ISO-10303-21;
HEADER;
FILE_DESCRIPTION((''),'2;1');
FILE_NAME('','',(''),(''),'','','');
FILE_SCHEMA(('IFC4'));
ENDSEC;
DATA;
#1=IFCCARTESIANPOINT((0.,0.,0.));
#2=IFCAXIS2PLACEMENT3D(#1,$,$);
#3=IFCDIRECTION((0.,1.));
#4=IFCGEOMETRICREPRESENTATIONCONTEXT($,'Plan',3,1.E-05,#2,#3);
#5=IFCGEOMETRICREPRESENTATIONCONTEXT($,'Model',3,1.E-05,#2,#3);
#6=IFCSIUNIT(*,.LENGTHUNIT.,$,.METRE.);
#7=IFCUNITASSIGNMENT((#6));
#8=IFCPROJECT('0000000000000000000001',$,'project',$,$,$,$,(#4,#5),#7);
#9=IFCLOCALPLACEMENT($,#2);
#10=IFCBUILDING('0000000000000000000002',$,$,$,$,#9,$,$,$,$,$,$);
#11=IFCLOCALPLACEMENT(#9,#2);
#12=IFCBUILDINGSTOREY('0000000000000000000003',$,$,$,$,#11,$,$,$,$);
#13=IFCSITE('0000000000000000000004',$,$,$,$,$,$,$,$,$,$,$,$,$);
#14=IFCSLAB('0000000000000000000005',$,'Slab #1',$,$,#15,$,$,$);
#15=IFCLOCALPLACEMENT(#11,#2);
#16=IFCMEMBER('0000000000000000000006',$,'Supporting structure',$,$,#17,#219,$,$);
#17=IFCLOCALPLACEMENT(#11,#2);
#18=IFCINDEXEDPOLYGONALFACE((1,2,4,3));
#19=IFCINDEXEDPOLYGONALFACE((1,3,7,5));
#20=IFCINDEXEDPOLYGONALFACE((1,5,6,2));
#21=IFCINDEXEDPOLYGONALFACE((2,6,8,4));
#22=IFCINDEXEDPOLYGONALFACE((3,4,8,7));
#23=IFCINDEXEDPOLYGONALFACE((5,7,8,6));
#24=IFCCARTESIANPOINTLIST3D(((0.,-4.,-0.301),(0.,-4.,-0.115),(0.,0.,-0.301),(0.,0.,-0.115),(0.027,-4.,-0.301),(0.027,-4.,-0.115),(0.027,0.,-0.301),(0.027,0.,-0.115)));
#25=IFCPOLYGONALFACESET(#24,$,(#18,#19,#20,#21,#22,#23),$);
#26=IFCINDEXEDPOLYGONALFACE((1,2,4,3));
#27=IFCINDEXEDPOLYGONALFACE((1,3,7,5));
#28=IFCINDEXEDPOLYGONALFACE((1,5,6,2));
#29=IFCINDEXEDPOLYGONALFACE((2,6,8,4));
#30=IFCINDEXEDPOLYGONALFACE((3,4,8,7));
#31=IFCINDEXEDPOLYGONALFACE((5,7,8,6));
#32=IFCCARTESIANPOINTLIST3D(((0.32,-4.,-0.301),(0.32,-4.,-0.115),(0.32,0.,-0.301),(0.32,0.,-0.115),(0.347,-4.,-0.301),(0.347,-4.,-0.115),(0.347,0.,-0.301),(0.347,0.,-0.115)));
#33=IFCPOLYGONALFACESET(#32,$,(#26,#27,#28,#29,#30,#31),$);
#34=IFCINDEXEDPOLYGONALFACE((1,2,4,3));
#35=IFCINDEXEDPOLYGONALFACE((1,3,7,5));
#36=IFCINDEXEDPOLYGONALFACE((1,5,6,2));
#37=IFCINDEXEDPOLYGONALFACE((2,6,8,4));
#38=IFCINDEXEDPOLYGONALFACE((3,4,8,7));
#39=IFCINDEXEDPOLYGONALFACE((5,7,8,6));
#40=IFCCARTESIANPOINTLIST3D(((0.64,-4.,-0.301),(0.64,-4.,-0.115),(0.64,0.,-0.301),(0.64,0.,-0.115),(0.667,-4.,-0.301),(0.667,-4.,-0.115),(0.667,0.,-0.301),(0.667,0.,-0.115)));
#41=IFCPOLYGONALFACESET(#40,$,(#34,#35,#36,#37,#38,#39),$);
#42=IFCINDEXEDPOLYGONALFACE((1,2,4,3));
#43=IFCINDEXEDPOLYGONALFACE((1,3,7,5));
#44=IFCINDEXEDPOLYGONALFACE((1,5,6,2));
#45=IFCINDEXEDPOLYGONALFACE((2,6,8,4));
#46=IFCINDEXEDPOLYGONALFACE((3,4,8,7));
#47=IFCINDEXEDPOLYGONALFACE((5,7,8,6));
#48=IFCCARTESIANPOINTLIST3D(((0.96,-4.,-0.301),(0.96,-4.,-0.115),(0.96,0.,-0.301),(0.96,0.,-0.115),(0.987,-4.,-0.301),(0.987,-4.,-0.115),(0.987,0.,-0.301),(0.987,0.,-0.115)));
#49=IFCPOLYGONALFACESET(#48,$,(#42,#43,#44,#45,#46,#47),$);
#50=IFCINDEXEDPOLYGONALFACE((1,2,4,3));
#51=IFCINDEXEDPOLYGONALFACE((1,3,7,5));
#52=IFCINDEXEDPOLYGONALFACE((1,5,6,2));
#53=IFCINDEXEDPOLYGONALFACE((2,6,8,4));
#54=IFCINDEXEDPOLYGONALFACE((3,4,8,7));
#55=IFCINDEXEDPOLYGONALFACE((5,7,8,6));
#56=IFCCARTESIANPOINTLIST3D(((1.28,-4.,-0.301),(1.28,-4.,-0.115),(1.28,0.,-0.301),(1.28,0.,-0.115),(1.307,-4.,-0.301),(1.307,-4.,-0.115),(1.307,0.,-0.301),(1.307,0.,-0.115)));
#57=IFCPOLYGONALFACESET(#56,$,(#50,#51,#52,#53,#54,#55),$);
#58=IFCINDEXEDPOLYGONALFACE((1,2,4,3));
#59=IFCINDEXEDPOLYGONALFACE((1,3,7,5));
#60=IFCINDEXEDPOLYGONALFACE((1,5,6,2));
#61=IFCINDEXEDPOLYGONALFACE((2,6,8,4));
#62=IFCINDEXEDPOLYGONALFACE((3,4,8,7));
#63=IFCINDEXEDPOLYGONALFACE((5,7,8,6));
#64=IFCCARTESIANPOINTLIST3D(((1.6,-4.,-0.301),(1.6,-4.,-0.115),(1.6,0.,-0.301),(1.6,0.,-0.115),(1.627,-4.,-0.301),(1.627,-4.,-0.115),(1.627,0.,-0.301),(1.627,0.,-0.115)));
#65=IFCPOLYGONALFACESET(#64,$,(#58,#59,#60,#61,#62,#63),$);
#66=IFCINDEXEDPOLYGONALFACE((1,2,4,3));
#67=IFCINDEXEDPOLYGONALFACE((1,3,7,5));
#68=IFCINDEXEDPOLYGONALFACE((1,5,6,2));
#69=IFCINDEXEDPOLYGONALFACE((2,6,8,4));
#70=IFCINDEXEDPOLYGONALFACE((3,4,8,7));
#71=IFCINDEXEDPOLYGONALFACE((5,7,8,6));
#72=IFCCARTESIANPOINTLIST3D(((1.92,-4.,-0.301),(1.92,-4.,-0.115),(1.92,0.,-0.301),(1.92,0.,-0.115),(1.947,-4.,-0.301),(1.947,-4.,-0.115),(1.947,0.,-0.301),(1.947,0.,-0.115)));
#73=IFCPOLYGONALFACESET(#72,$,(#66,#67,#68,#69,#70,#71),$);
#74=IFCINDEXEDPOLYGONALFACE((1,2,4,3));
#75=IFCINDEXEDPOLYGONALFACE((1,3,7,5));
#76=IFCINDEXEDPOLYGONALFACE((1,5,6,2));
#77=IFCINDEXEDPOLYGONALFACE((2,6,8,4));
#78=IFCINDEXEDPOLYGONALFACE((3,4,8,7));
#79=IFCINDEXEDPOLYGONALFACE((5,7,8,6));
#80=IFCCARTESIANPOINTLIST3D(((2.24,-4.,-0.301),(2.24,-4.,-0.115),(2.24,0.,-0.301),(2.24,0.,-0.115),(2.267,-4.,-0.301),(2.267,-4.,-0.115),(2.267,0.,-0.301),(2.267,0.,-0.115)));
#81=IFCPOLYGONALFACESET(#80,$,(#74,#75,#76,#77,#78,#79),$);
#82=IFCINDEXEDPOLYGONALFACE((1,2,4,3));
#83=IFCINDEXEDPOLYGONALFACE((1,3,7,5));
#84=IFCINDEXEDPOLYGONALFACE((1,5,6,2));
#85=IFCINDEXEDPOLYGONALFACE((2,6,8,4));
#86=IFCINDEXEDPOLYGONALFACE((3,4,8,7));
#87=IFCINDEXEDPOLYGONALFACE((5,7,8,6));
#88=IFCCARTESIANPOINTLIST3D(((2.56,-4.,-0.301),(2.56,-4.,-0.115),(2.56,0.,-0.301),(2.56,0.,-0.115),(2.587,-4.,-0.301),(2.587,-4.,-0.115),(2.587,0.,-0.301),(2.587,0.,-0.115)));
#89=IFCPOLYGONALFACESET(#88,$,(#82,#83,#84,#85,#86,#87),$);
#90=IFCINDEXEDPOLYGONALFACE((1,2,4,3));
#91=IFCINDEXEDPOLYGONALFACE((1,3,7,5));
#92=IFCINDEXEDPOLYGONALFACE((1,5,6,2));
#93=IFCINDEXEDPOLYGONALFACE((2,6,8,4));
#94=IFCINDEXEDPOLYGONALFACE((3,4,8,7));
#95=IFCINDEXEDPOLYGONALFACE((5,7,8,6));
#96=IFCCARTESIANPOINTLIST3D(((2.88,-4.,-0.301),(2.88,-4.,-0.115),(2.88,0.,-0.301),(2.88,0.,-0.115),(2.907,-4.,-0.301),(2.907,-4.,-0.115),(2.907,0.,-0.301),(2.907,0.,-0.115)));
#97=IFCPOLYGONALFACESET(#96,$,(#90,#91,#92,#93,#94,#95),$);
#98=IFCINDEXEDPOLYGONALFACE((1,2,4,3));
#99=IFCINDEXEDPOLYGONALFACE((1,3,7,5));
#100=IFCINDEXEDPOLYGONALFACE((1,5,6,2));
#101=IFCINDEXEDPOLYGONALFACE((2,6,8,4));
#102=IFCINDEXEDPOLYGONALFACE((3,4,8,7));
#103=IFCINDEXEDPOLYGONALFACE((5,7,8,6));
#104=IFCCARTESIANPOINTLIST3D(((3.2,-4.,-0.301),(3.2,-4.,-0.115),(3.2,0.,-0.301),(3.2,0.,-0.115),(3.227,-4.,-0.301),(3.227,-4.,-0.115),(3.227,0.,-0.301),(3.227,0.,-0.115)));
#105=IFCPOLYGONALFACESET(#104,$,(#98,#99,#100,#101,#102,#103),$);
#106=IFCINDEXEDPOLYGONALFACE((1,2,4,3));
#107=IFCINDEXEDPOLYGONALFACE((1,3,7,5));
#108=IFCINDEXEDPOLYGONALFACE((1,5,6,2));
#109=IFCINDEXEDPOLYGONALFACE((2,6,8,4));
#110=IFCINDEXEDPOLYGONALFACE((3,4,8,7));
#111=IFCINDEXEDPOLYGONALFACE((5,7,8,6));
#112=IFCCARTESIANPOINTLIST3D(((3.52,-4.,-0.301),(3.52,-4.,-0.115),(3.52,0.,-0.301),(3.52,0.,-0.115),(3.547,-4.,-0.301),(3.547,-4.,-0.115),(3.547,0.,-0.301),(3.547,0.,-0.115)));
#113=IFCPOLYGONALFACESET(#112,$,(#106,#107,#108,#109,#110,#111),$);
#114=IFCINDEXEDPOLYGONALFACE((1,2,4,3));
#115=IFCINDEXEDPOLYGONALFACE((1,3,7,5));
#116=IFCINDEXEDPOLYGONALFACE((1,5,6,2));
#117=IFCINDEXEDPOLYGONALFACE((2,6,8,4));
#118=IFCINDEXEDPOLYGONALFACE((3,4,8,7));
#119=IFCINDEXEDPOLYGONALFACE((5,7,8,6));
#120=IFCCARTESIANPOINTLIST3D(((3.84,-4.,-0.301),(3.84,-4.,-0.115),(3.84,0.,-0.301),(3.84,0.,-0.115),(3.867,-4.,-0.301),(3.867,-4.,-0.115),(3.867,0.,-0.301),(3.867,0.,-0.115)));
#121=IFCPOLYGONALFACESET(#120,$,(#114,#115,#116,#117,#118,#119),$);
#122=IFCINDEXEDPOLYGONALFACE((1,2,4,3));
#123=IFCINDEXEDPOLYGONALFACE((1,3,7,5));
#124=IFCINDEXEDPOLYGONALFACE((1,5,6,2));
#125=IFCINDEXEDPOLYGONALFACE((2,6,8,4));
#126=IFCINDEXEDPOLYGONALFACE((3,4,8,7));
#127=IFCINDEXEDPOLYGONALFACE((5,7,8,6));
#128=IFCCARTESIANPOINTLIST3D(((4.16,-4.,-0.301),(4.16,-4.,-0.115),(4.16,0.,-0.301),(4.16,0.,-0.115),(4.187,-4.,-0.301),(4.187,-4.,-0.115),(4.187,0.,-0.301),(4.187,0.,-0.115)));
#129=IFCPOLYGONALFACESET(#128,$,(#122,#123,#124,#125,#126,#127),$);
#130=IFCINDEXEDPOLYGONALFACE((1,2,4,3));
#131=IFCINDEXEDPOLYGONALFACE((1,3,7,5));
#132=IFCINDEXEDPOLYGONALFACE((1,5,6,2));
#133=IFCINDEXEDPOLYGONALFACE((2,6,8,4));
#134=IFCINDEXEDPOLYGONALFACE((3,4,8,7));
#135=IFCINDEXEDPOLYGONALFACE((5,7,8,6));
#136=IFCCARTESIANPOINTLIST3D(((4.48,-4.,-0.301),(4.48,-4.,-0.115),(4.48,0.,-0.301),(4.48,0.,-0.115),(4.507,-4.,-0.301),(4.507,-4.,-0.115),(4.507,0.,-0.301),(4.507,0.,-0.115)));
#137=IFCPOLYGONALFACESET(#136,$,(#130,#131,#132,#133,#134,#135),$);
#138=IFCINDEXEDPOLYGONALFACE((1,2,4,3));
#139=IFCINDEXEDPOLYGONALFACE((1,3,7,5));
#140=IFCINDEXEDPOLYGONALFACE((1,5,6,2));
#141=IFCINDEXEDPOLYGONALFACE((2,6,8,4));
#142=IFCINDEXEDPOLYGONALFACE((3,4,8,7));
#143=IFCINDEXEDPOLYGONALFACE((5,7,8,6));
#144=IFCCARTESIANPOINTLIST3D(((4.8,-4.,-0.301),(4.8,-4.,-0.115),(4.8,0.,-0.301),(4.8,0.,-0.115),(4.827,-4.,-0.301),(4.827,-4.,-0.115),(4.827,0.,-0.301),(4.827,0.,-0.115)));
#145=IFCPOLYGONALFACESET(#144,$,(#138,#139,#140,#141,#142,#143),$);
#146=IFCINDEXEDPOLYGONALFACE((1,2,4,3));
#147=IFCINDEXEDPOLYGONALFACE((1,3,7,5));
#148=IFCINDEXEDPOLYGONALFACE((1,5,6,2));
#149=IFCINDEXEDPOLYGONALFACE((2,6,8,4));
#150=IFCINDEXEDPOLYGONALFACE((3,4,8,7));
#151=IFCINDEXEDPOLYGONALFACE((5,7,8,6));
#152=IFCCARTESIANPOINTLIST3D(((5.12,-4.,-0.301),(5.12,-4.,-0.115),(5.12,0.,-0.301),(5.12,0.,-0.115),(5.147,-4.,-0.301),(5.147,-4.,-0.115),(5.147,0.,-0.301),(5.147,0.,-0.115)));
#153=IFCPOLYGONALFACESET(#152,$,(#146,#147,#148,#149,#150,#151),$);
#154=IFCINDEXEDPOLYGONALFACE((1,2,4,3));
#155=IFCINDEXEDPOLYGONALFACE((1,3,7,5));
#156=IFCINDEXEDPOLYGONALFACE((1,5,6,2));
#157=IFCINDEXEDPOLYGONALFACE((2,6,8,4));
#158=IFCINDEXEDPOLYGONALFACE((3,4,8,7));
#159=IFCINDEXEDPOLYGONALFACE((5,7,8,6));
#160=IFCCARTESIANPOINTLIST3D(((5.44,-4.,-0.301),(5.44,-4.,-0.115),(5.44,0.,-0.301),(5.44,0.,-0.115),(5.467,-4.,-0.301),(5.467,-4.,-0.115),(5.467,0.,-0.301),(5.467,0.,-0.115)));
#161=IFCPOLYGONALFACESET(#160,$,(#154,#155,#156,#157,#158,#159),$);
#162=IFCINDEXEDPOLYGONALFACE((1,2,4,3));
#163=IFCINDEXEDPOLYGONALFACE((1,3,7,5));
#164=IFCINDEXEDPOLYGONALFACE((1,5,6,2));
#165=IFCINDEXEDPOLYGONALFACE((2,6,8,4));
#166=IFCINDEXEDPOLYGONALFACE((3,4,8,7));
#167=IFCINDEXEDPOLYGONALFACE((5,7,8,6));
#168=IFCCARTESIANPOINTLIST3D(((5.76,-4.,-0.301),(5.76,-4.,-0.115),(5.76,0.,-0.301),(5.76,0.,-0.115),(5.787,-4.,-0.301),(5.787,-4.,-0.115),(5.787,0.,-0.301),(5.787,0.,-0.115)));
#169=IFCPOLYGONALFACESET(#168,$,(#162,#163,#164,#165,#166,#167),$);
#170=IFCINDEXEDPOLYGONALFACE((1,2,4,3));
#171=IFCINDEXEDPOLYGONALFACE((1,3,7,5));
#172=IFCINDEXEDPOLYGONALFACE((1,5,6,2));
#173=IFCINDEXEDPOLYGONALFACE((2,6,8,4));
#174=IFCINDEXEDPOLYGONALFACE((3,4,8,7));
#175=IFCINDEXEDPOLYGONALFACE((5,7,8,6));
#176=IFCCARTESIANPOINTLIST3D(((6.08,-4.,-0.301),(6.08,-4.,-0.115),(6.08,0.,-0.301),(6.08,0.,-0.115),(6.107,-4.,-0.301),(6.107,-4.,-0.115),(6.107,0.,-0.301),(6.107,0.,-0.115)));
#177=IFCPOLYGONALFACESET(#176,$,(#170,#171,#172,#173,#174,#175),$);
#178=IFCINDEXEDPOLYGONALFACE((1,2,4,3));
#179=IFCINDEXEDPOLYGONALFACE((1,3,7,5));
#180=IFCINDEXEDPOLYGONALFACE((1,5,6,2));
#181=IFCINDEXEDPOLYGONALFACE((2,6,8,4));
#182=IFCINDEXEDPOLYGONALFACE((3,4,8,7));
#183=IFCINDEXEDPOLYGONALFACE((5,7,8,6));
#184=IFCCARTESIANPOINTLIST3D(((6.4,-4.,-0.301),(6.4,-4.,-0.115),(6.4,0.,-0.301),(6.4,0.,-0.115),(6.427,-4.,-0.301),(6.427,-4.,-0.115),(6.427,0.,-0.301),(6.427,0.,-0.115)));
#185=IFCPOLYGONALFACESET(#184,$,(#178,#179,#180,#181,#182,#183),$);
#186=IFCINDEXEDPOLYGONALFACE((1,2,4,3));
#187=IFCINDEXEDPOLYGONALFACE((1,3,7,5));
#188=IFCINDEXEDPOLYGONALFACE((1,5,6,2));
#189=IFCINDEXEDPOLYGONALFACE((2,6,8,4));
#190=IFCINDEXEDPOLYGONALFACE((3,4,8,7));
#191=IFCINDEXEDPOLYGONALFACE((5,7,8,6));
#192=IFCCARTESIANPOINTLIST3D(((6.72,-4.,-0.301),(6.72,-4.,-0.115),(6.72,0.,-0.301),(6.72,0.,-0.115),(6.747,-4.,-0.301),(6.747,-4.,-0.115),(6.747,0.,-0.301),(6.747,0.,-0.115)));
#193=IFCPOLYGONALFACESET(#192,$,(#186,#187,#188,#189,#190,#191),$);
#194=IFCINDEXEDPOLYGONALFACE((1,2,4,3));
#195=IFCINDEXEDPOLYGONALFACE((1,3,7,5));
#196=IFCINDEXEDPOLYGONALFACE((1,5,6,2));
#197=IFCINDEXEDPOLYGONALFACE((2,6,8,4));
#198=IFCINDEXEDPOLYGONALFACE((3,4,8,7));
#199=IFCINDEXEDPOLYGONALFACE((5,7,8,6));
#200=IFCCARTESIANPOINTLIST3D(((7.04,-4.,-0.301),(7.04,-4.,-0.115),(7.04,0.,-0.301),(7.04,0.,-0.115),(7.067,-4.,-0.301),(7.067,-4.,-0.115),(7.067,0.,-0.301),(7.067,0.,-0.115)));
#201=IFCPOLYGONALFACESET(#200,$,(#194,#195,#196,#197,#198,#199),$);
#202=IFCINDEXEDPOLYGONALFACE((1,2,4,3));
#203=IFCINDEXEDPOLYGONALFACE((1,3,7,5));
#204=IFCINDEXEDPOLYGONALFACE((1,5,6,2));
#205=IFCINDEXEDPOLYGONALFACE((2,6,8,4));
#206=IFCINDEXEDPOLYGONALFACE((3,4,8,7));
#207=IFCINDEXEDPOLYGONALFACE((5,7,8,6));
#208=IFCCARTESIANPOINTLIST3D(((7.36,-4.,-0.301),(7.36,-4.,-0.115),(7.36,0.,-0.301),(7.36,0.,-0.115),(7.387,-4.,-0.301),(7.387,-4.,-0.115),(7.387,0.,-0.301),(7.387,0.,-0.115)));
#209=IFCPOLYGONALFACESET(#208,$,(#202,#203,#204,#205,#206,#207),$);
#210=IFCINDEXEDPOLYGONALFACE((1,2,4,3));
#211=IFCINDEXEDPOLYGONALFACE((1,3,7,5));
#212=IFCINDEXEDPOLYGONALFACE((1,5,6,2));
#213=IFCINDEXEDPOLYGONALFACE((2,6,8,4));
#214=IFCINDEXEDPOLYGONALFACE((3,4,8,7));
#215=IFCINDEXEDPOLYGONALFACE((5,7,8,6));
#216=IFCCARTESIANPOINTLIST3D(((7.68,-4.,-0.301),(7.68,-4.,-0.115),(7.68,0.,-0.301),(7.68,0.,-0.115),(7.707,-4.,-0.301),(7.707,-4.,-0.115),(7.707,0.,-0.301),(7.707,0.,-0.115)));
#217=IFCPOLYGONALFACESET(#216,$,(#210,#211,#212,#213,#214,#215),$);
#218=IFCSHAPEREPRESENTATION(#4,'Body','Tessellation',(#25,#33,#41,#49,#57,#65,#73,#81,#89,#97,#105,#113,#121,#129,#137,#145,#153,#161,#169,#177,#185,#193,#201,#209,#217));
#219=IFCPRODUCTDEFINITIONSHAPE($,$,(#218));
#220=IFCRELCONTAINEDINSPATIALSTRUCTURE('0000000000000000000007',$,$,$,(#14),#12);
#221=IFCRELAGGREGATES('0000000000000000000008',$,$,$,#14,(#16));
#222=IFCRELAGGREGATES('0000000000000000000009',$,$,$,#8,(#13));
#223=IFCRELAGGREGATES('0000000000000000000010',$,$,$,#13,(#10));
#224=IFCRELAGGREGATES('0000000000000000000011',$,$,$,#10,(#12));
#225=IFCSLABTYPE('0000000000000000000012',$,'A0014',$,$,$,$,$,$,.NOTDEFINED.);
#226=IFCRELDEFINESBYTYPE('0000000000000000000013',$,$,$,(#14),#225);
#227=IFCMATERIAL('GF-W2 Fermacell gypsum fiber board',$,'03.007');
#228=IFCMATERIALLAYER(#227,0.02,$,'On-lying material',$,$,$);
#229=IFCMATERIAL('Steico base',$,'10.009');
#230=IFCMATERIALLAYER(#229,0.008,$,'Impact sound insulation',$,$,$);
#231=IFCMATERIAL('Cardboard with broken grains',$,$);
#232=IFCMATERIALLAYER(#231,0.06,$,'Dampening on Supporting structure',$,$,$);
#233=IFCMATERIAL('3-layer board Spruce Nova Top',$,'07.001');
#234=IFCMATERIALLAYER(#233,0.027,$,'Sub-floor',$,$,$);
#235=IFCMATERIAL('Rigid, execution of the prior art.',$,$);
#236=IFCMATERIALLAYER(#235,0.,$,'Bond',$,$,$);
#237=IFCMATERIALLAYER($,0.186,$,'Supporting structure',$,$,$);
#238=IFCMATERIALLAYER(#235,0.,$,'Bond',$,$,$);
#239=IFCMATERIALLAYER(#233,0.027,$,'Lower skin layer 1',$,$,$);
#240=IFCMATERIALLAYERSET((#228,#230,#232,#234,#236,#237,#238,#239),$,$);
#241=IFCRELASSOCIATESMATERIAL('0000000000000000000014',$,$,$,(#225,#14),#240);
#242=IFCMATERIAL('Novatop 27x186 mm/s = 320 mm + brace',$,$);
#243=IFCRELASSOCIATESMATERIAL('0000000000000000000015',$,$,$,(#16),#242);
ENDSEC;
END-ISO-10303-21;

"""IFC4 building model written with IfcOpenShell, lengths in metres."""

from ifc_helpers import new_model, si_unit, direction, frame, frame_2d, origin, place, context, project, spatial, rectangle, extrude, material, layer, layer_set, type_object, element, aggregate, save


model = new_model("IFC4")

# Units and contexts
plan_context = context("Plan", 3, precision=1e-05, world=origin(), true_north=direction((0.0, 1.0)))
model_context = context("Model", 3, precision=1e-05, world=origin(), true_north=direction((0.0, 1.0)))
ifc_project = project(units=[si_unit("LENGTHUNIT", "METRE")], contexts=[plan_context, model_context])

# Site, building, storey
site = spatial("IfcSite", under=ifc_project)
building_placement = place(None, origin())
building = spatial("IfcBuilding", under=site, at=building_placement)
storey_placement = place(building_placement, origin())
storey = spatial("IfcBuildingStorey", under=building, at=storey_placement)

# Slab, member
ifc_material_1 = material(Name="GF-W2 Fermacell gypsum fiber board", Category="03.007")
ifc_layer_1 = layer(ifc_material_1, 0.02, Name="On-lying material")
ifc_material_2 = material(Name="Steico base", Category="10.009")
ifc_layer_2 = layer(ifc_material_2, 0.008, Name="Impact sound insulation")
ifc_material_3 = material(Name="Cardboard with broken grains")
ifc_layer_3 = layer(ifc_material_3, 0.06, Name="Dampening on Supporting structure")
ifc_material_4 = material(Name="3-layer board Spruce Nova Top", Category="07.001")
ifc_layer_4 = layer(ifc_material_4, 0.027, Name="Sub-floor")
ifc_material_5 = material(Name="Rigid, execution of the prior art.")
ifc_layer_5 = layer(ifc_material_5, 0.0, Name="Bond")
ifc_layer_6 = layer(None, 0.186, Name="Supporting structure")
ifc_layer_7 = layer(ifc_material_5, 0.0, Name="Bond")
ifc_layer_8 = layer(ifc_material_4, 0.027, Name="Lower skin layer 1")
ifc_layer_set = layer_set([ifc_layer_1, ifc_layer_2, ifc_layer_3, ifc_layer_4, ifc_layer_5, ifc_layer_6, ifc_layer_7, ifc_layer_8])
slab_type = type_object("IfcSlabType", Name="A0014", PredefinedType="NOTDEFINED", material=ifc_layer_set)
slab_placement = place(None, frame((0.0, 0.0, 0.0), z_axis=(0.0, 0.0, -1.0), x_axis=(1.0, 0.0, 0.0)))
slab = element("IfcSlab", 1, at=slab_placement, inside=storey, type_object=slab_type, material=ifc_layer_set, Name="Slab #1")
ifc_material_6 = material(Name="Novatop 27x186 mm/s = 320 mm + brace")
member_placement = place(slab_placement, origin())
member = element("IfcMember", 2, at=member_placement, material=ifc_material_6, Name="Supporting structure", context=plan_context, shape_type="SweptSolid", body=[
    extrude(rectangle(XDim=0.027, YDim=0.186, at=frame_2d((0.0135, 0.093), x_axis=(1.0, 0.0))), frame((0.0, 4.0, 0.115), z_axis=(0.0, -1.0, 0.0), x_axis=(1.0, 0.0, 0.0)), (0.0, 0.0, 1.0), 4.0),
    extrude(rectangle(XDim=0.027, YDim=0.186, at=frame_2d((0.0135, 0.093), x_axis=(1.0, 0.0))), frame((0.32, 4.0, 0.115), z_axis=(0.0, -1.0, 0.0), x_axis=(1.0, 0.0, 0.0)), (0.0, 0.0, 1.0), 4.0),
    extrude(rectangle(XDim=0.027, YDim=0.186, at=frame_2d((0.0135, 0.093), x_axis=(1.0, 0.0))), frame((0.64, 4.0, 0.115), z_axis=(0.0, -1.0, 0.0), x_axis=(1.0, 0.0, 0.0)), (0.0, 0.0, 1.0), 4.0),
    extrude(rectangle(XDim=0.027, YDim=0.186, at=frame_2d((0.0135, 0.093), x_axis=(1.0, 0.0))), frame((0.96, 4.0, 0.115), z_axis=(0.0, -1.0, 0.0), x_axis=(1.0, 0.0, 0.0)), (0.0, 0.0, 1.0), 4.0),
    extrude(rectangle(XDim=0.027, YDim=0.186, at=frame_2d((0.0135, 0.093), x_axis=(1.0, 0.0))), frame((1.28, 4.0, 0.115), z_axis=(0.0, -1.0, 0.0), x_axis=(1.0, 0.0, 0.0)), (0.0, 0.0, 1.0), 4.0),
    extrude(rectangle(XDim=0.027, YDim=0.186, at=frame_2d((0.0135, 0.093), x_axis=(1.0, 0.0))), frame((1.6, 4.0, 0.115), z_axis=(0.0, -1.0, 0.0), x_axis=(1.0, 0.0, 0.0)), (0.0, 0.0, 1.0), 4.0),
    extrude(rectangle(XDim=0.027, YDim=0.186, at=frame_2d((0.0135, 0.093), x_axis=(1.0, 0.0))), frame((1.92, 4.0, 0.115), z_axis=(0.0, -1.0, 0.0), x_axis=(1.0, 0.0, 0.0)), (0.0, 0.0, 1.0), 4.0),
    extrude(rectangle(XDim=0.027, YDim=0.186, at=frame_2d((0.0135, 0.093), x_axis=(1.0, 0.0))), frame((2.24, 4.0, 0.115), z_axis=(0.0, -1.0, 0.0), x_axis=(1.0, 0.0, 0.0)), (0.0, 0.0, 1.0), 4.0),
    extrude(rectangle(XDim=0.027, YDim=0.186, at=frame_2d((0.0135, 0.093), x_axis=(1.0, 0.0))), frame((2.56, 4.0, 0.115), z_axis=(0.0, -1.0, 0.0), x_axis=(1.0, 0.0, 0.0)), (0.0, 0.0, 1.0), 4.0),
    extrude(rectangle(XDim=0.027, YDim=0.186, at=frame_2d((0.0135, 0.093), x_axis=(1.0, 0.0))), frame((2.88, 4.0, 0.115), z_axis=(0.0, -1.0, 0.0), x_axis=(1.0, 0.0, 0.0)), (0.0, 0.0, 1.0), 4.0),
    extrude(rectangle(XDim=0.027, YDim=0.186, at=frame_2d((0.0135, 0.093), x_axis=(1.0, 0.0))), frame((3.2, 4.0, 0.115), z_axis=(0.0, -1.0, 0.0), x_axis=(1.0, 0.0, 0.0)), (0.0, 0.0, 1.0), 4.0),
    extrude(rectangle(XDim=0.027, YDim=0.186, at=frame_2d((0.0135, 0.093), x_axis=(1.0, 0.0))), frame((3.52, 4.0, 0.115), z_axis=(0.0, -1.0, 0.0), x_axis=(1.0, 0.0, 0.0)), (0.0, 0.0, 1.0), 4.0),
    extrude(rectangle(XDim=0.027, YDim=0.186, at=frame_2d((0.0135, 0.093), x_axis=(1.0, 0.0))), frame((3.84, 4.0, 0.115), z_axis=(0.0, -1.0, 0.0), x_axis=(1.0, 0.0, 0.0)), (0.0, 0.0, 1.0), 4.0),
    extrude(rectangle(XDim=0.027, YDim=0.186, at=frame_2d((0.0135, 0.093), x_axis=(1.0, 0.0))), frame((4.16, 4.0, 0.115), z_axis=(0.0, -1.0, 0.0), x_axis=(1.0, 0.0, 0.0)), (0.0, 0.0, 1.0), 4.0),
    extrude(rectangle(XDim=0.027, YDim=0.186, at=frame_2d((0.0135, 0.093), x_axis=(1.0, 0.0))), frame((4.48, 4.0, 0.115), z_axis=(0.0, -1.0, 0.0), x_axis=(1.0, 0.0, 0.0)), (0.0, 0.0, 1.0), 4.0),
    extrude(rectangle(XDim=0.027, YDim=0.186, at=frame_2d((0.0135, 0.093), x_axis=(1.0, 0.0))), frame((4.8, 4.0, 0.115), z_axis=(0.0, -1.0, 0.0), x_axis=(1.0, 0.0, 0.0)), (0.0, 0.0, 1.0), 4.0),
    extrude(rectangle(XDim=0.027, YDim=0.186, at=frame_2d((0.0135, 0.093), x_axis=(1.0, 0.0))), frame((5.12, 4.0, 0.115), z_axis=(0.0, -1.0, 0.0), x_axis=(1.0, 0.0, 0.0)), (0.0, 0.0, 1.0), 4.0),
    extrude(rectangle(XDim=0.027, YDim=0.186, at=frame_2d((0.0135, 0.093), x_axis=(1.0, 0.0))), frame((5.44, 4.0, 0.115), z_axis=(0.0, -1.0, 0.0), x_axis=(1.0, 0.0, 0.0)), (0.0, 0.0, 1.0), 4.0),
    extrude(rectangle(XDim=0.027, YDim=0.186, at=frame_2d((0.0135, 0.093), x_axis=(1.0, 0.0))), frame((5.76, 4.0, 0.115), z_axis=(0.0, -1.0, 0.0), x_axis=(1.0, 0.0, 0.0)), (0.0, 0.0, 1.0), 4.0),
    extrude(rectangle(XDim=0.027, YDim=0.186, at=frame_2d((0.0135, 0.093), x_axis=(1.0, 0.0))), frame((6.08, 4.0, 0.115), z_axis=(0.0, -1.0, 0.0), x_axis=(1.0, 0.0, 0.0)), (0.0, 0.0, 1.0), 4.0),
    extrude(rectangle(XDim=0.027, YDim=0.186, at=frame_2d((0.0135, 0.093), x_axis=(1.0, 0.0))), frame((6.4, 4.0, 0.115), z_axis=(0.0, -1.0, 0.0), x_axis=(1.0, 0.0, 0.0)), (0.0, 0.0, 1.0), 4.0),
    extrude(rectangle(XDim=0.027, YDim=0.186, at=frame_2d((0.0135, 0.093), x_axis=(1.0, 0.0))), frame((6.72, 4.0, 0.115), z_axis=(0.0, -1.0, 0.0), x_axis=(1.0, 0.0, 0.0)), (0.0, 0.0, 1.0), 4.0),
    extrude(rectangle(XDim=0.027, YDim=0.186, at=frame_2d((0.0135, 0.093), x_axis=(1.0, 0.0))), frame((7.04, 4.0, 0.115), z_axis=(0.0, -1.0, 0.0), x_axis=(1.0, 0.0, 0.0)), (0.0, 0.0, 1.0), 4.0),
    extrude(rectangle(XDim=0.027, YDim=0.186, at=frame_2d((0.0135, 0.093), x_axis=(1.0, 0.0))), frame((7.36, 4.0, 0.115), z_axis=(0.0, -1.0, 0.0), x_axis=(1.0, 0.0, 0.0)), (0.0, 0.0, 1.0), 4.0),
    extrude(rectangle(XDim=0.027, YDim=0.186, at=frame_2d((0.0135, 0.093), x_axis=(1.0, 0.0))), frame((7.68, 4.0, 0.115), z_axis=(0.0, -1.0, 0.0), x_axis=(1.0, 0.0, 0.0)), (0.0, 0.0, 1.0), 4.0),
])
aggregate(slab, [member])

save(model, "model.ifc")
